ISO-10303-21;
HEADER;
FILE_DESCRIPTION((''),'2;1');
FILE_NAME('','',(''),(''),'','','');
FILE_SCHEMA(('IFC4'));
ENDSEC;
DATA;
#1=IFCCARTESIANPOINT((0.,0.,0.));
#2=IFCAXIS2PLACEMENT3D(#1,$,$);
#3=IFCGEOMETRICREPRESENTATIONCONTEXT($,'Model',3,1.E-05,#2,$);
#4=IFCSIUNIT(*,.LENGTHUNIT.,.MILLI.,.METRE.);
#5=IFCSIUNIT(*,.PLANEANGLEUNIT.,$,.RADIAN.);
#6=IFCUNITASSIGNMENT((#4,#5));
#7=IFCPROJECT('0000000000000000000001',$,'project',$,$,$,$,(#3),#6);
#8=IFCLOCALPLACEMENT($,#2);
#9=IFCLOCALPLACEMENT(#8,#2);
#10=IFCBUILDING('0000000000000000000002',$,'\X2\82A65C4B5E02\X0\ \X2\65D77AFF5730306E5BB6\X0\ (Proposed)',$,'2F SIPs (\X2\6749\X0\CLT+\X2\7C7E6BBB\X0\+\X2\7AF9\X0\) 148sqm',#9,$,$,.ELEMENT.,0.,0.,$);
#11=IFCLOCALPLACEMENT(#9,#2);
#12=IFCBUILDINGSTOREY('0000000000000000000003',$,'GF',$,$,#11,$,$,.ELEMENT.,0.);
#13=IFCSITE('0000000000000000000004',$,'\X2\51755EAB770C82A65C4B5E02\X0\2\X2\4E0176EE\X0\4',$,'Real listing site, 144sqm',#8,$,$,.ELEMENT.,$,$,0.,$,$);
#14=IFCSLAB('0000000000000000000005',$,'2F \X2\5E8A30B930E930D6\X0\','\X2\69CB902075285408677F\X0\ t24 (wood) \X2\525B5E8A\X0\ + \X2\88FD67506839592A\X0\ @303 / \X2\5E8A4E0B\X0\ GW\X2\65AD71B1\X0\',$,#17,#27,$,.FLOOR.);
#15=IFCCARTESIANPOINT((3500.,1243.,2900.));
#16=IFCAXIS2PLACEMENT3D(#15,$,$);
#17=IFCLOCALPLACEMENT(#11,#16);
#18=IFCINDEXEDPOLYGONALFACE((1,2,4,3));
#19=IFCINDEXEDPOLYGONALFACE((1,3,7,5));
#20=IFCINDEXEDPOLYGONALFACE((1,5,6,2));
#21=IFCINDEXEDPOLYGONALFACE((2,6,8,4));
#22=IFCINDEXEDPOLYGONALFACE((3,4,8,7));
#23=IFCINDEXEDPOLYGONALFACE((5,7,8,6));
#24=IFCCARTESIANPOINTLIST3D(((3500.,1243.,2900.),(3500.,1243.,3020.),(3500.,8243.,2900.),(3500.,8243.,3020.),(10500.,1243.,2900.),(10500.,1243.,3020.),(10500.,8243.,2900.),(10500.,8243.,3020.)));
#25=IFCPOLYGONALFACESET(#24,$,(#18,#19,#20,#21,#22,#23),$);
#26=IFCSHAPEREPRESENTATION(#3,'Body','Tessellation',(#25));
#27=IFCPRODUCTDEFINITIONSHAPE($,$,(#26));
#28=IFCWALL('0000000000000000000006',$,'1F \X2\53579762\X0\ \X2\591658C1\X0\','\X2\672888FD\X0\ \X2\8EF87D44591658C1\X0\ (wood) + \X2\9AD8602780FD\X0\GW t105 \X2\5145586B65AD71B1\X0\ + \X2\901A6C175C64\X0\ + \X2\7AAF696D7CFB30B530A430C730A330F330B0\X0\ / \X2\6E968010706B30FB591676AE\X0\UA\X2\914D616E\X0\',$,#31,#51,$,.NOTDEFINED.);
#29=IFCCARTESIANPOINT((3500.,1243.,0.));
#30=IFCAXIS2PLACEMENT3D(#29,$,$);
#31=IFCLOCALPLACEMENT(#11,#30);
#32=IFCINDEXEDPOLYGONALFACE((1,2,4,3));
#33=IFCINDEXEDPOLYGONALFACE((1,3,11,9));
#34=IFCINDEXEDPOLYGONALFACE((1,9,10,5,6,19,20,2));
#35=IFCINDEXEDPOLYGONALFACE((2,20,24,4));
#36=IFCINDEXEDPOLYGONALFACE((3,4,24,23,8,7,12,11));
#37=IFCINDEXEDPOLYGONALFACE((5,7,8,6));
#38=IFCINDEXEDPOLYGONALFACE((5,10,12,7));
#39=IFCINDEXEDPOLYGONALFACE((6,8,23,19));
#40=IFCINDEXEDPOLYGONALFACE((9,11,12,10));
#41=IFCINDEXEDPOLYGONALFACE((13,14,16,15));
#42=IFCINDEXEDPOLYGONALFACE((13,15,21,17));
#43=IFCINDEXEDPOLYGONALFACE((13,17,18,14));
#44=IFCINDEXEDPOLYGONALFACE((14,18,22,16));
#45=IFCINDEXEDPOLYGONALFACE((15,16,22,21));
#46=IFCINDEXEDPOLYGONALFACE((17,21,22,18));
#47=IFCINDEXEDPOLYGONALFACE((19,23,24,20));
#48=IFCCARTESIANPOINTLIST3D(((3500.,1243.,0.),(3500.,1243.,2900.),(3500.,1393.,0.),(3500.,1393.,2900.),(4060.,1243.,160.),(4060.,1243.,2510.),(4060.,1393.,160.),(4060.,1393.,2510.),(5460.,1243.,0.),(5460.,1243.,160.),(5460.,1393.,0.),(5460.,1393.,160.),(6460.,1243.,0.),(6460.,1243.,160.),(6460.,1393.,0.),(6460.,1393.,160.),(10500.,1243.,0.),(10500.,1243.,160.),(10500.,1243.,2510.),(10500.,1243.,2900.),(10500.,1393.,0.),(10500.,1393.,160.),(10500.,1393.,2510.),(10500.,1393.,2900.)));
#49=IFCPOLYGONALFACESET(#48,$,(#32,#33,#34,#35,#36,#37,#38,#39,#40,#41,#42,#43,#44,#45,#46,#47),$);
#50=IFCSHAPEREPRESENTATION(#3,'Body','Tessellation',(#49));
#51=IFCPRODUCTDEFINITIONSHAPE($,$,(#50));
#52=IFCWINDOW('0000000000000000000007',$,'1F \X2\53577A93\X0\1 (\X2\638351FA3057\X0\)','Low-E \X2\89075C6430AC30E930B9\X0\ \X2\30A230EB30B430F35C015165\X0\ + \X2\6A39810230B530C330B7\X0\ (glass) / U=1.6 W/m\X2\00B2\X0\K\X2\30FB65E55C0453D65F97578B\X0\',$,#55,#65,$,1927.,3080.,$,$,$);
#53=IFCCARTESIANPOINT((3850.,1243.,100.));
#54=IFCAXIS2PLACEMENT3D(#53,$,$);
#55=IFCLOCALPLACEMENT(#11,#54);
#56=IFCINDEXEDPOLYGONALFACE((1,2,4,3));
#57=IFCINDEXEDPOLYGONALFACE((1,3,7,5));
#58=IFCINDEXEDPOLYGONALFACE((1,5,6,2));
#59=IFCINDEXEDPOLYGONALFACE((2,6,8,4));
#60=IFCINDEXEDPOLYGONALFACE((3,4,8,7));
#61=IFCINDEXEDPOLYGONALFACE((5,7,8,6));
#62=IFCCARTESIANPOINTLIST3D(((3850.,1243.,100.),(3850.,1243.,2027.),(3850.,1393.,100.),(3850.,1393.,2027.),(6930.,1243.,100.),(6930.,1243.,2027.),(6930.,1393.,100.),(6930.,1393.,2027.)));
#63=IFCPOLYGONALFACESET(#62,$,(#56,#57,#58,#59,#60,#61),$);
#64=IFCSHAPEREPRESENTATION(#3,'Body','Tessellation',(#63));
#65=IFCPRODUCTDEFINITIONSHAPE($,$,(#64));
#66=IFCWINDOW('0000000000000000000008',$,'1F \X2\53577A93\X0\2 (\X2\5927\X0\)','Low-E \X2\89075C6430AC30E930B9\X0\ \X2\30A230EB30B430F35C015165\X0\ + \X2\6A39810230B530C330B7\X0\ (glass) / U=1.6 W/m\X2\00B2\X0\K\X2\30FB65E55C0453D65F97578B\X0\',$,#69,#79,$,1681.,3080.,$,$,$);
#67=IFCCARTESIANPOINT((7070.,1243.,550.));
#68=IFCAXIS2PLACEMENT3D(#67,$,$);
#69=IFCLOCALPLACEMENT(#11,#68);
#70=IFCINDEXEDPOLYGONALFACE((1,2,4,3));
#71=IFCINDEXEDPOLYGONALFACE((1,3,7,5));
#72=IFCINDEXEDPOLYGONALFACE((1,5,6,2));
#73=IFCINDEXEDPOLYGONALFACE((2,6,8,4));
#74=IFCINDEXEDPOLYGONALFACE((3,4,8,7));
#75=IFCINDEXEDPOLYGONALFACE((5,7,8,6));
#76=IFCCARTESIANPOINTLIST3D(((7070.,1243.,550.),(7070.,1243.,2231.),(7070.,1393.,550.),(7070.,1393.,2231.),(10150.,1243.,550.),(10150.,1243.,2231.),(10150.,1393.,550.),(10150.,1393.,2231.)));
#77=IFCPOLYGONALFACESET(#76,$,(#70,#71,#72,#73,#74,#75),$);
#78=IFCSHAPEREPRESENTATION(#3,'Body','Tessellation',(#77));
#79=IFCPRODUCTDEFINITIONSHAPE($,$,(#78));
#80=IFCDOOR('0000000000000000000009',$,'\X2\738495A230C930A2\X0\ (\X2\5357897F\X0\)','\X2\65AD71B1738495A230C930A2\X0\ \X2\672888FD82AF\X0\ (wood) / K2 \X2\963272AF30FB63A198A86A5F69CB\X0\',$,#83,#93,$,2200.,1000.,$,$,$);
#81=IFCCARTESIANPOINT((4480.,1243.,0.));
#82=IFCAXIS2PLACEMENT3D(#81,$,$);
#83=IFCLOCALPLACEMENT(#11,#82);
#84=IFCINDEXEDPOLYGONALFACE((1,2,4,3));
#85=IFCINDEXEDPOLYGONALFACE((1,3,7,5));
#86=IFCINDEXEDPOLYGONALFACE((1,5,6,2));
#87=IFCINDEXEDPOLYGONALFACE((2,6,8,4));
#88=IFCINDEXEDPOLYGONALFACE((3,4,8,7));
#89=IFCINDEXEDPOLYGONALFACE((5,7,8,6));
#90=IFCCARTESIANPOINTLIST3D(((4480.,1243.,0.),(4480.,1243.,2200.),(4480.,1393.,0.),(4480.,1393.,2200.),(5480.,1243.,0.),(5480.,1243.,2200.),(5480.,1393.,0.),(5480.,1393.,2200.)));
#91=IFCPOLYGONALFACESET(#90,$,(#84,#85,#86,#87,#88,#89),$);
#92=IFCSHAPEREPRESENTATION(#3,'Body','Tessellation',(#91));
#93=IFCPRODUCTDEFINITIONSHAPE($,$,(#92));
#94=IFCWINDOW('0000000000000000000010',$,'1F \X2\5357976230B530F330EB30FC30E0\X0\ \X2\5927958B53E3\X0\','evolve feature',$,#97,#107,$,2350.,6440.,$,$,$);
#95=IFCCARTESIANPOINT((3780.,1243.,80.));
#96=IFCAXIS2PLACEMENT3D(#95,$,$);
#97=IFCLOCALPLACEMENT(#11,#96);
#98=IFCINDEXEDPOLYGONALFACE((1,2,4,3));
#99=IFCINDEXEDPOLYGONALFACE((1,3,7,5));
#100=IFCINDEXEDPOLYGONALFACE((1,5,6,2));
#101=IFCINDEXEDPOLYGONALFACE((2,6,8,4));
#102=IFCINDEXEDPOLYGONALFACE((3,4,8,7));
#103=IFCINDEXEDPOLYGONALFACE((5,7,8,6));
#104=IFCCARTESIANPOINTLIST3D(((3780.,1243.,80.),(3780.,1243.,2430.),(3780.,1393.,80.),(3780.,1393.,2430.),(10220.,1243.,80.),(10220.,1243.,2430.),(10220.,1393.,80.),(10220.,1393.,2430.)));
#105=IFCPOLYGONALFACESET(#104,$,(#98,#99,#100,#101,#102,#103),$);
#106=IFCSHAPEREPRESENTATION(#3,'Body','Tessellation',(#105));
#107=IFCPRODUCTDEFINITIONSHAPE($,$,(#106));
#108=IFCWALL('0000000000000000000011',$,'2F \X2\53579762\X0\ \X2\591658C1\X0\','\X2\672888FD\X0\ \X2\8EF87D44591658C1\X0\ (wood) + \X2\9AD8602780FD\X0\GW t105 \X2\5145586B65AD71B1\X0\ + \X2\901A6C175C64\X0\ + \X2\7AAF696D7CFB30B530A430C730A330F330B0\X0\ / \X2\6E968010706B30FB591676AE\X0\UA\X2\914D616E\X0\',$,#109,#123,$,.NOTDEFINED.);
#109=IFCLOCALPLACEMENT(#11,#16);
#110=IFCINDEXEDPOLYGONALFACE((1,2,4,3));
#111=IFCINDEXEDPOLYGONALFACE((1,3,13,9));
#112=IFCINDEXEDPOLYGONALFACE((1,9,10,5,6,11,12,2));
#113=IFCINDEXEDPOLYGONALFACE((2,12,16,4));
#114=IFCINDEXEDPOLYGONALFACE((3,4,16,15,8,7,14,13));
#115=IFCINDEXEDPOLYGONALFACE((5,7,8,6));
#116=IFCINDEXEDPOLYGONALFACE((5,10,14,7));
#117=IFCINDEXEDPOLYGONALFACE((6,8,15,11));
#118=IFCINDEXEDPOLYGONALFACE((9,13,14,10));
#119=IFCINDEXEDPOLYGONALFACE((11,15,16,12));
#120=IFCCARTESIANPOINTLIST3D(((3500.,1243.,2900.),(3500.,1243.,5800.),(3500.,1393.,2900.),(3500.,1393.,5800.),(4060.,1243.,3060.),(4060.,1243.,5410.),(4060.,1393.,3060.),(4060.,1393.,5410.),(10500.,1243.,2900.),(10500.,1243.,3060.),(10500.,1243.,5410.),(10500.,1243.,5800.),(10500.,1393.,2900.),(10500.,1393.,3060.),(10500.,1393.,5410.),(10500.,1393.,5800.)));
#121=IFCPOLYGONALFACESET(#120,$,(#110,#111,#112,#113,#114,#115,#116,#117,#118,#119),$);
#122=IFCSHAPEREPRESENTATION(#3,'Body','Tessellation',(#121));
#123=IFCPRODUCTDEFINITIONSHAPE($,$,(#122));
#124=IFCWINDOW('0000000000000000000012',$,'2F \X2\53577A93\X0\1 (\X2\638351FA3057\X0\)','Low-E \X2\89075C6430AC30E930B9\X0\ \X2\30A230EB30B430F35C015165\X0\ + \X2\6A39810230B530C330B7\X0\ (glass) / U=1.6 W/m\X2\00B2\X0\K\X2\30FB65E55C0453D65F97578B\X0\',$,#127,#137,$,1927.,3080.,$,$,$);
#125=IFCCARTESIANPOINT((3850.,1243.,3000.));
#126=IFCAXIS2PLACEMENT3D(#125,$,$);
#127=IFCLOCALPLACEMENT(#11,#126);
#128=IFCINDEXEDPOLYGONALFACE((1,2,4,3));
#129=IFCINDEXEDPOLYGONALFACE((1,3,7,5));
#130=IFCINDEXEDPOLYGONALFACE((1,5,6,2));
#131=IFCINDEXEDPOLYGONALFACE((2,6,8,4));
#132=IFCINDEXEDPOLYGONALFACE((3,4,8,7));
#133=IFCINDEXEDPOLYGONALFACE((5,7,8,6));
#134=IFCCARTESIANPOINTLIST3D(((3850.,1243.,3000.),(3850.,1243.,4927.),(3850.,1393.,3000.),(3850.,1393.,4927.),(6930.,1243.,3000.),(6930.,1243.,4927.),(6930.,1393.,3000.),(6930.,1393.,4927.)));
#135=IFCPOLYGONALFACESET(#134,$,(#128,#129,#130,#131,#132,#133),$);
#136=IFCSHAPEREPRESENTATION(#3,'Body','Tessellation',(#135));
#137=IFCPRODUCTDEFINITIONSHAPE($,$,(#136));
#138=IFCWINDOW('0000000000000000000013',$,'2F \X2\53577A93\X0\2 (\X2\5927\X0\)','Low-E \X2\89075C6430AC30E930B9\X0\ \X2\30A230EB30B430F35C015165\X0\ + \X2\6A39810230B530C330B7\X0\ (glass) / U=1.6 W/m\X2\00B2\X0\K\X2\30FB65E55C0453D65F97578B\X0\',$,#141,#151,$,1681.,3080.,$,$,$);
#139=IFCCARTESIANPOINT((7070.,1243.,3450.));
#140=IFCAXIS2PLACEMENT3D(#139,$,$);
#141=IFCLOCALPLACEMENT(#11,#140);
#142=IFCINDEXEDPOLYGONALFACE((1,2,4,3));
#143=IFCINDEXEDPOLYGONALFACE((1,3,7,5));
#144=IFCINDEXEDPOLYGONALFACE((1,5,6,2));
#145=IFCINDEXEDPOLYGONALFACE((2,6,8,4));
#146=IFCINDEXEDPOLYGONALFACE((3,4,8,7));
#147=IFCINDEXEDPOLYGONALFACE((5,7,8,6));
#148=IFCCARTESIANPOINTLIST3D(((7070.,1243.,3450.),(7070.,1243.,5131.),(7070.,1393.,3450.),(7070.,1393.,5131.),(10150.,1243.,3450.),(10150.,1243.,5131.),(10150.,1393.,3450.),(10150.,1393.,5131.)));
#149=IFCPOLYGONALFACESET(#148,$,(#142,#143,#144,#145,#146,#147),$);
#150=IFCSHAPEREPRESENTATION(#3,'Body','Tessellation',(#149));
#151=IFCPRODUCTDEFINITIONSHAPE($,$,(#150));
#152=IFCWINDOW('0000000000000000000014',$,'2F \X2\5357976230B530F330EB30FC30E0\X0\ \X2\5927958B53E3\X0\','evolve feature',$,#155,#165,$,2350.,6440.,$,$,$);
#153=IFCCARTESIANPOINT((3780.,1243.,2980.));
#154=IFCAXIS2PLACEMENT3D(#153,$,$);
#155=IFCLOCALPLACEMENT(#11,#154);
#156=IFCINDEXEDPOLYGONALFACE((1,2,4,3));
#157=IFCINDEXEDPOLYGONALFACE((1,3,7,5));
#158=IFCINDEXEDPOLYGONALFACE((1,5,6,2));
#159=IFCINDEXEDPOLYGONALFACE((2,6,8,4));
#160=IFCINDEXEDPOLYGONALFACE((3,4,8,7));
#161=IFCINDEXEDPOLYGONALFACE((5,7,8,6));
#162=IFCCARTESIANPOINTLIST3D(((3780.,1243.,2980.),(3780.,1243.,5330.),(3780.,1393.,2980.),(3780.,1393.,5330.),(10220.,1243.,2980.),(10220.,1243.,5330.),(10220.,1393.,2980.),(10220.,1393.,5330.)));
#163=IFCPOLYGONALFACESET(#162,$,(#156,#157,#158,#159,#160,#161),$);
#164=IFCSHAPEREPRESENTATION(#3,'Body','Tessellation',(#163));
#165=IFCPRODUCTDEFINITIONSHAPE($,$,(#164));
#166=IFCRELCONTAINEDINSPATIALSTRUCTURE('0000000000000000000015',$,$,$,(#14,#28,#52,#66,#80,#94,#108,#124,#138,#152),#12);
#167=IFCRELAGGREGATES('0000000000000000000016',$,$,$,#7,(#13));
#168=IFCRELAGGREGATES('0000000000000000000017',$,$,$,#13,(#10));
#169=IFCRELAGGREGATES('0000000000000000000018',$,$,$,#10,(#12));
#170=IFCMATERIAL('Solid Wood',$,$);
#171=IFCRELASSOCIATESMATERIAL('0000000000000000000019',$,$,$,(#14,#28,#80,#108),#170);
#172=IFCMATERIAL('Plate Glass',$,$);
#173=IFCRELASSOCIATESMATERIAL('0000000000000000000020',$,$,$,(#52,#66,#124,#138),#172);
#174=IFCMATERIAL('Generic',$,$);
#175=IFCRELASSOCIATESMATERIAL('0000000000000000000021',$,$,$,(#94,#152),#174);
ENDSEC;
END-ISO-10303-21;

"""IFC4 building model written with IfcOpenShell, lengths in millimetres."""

from ifc_helpers import new_model, si_unit, frame, frame_2d, origin, place, context, project, spatial, rectangle, extrude, material, element, fill, save


model = new_model("IFC4")

# Units and contexts
model_context = context("Model", 3, precision=1e-05, world=origin())
ifc_project = project(units=[si_unit("LENGTHUNIT", "METRE", prefix="MILLI"), si_unit("PLANEANGLEUNIT", "RADIAN")], contexts=[model_context])

# Site, building, storey
site_placement = place(None, origin())
site = spatial("IfcSite", under=ifc_project, at=site_placement, Name="兵庫県芦屋市2丁目4", ObjectType="Real listing site, 144sqm", CompositionType="ELEMENT", RefElevation=0.0)
building_placement = place(site_placement, origin())
building = spatial("IfcBuilding", under=site, at=building_placement, Name="芦屋市 旗竿地の家 (Proposed)", ObjectType="2F SIPs (杉CLT+籾殻+竹) 148sqm", CompositionType="ELEMENT", ElevationOfRefHeight=0.0, ElevationOfTerrain=0.0)
storey_placement = place(building_placement, origin())
storey = spatial("IfcBuildingStorey", under=building, at=storey_placement, Name="GF", CompositionType="ELEMENT", Elevation=0.0)

# Slab
ifc_material_1 = material(Name="Solid Wood")
slab_1_placement = place(storey_placement, frame((3500.0, 1243.0, 2900.0)))
element("IfcSlab", 1, at=slab_1_placement, inside=storey, material=ifc_material_1, Name="2F 床スラブ", Description="構造用合板 t24 (wood) 剛床 + 製材根太 @303 / 床下 GW断熱", PredefinedType="FLOOR", context=model_context, shape_type="SweptSolid", body=[
    extrude(rectangle(XDim=7000.0, YDim=7000.0, at=frame_2d((3500.0, 3500.0))), frame((3500.0, 1243.0, 2900.0)), (0.0, 0.0, 1.0), 120.0),
])
ifc_material_2 = material(Name="Generic")

# Wall, openings, windows, door
wall_1_placement = place(storey_placement, frame((3500.0, 1243.0, 0.0)))
wall_1 = element("IfcWall", 2, at=wall_1_placement, inside=storey, material=ifc_material_1, Name="1F 南面 外壁", Description="木製 軸組外壁 (wood) + 高性能GW t105 充填断熱 + 通気層 + 窯業系サイディング / 準耐火・外皮UA配慮", PredefinedType="NOTDEFINED", context=model_context, shape_type="SweptSolid", body=[
    extrude(rectangle(XDim=7000.0, YDim=150.0, at=frame_2d((3500.0, 75.0))), frame((3500.0, 1243.0, 0.0)), (0.0, 0.0, 1.0), 2900.0),
])
opening_1_placement = place(storey_placement, frame((3850.0, 1243.0, 100.0)))
opening_1 = element("IfcOpeningElement", 3, at=opening_1_placement, cuts=wall_1, PredefinedType="NOTDEFINED", context=model_context, shape_type="SweptSolid", body=[
    extrude(rectangle(XDim=3080.0, YDim=150.0, at=frame_2d((1540.0, 75.0))), frame((3850.0, 1243.0, 100.0)), (0.0, 0.0, 1.0), 1927.0),
])
opening_2_placement = place(storey_placement, frame((7070.0, 1243.0, 550.0)))
opening_2 = element("IfcOpeningElement", 4, at=opening_2_placement, cuts=wall_1, PredefinedType="NOTDEFINED", context=model_context, shape_type="SweptSolid", body=[
    extrude(rectangle(XDim=3080.0, YDim=150.0, at=frame_2d((1540.0, 75.0))), frame((7070.0, 1243.0, 550.0)), (0.0, 0.0, 1.0), 1681.0),
])
opening_3_placement = place(storey_placement, frame((4480.0, 1243.0, 0.0)))
opening_3 = element("IfcOpeningElement", 5, at=opening_3_placement, cuts=wall_1, PredefinedType="NOTDEFINED", context=model_context, shape_type="SweptSolid", body=[
    extrude(rectangle(XDim=1000.0, YDim=150.0, at=frame_2d((500.0, 75.0))), frame((4480.0, 1243.0, 0.0)), (0.0, 0.0, 1.0), 2200.0),
])
opening_4_placement = place(storey_placement, frame((3780.0, 1243.0, 80.0)))
opening_4 = element("IfcOpeningElement", 6, at=opening_4_placement, cuts=wall_1, PredefinedType="NOTDEFINED", context=model_context, shape_type="SweptSolid", body=[
    extrude(rectangle(XDim=6440.0, YDim=150.0, at=frame_2d((3220.0, 75.0))), frame((3780.0, 1243.0, 80.0)), (0.0, 0.0, 1.0), 2350.0),
])
ifc_material_3 = material(Name="Plate Glass")
window_1_placement = place(storey_placement, frame((3850.0, 1243.0, 100.0)))
window_1 = element("IfcWindow", 7, at=window_1_placement, inside=storey, material=ifc_material_3, Name="1F 南窓1 (掃出し)", Description="Low-E 複層ガラス アルゴン封入 + 樹脂サッシ (glass) / U=1.6 W/m²K・日射取得型", OverallHeight=1927.0, OverallWidth=3080.0, context=model_context, shape_type="SweptSolid", body=[
    extrude(rectangle(XDim=3080.0, YDim=150.0, at=frame_2d((1540.0, 75.0))), frame((3850.0, 1243.0, 100.0)), (0.0, 0.0, 1.0), 1927.0),
])
fill(opening_1, window_1)
window_2_placement = place(storey_placement, frame((7070.0, 1243.0, 550.0)))
window_2 = element("IfcWindow", 8, at=window_2_placement, inside=storey, material=ifc_material_3, Name="1F 南窓2 (大)", Description="Low-E 複層ガラス アルゴン封入 + 樹脂サッシ (glass) / U=1.6 W/m²K・日射取得型", OverallHeight=1681.0, OverallWidth=3080.0, context=model_context, shape_type="SweptSolid", body=[
    extrude(rectangle(XDim=3080.0, YDim=150.0, at=frame_2d((1540.0, 75.0))), frame((7070.0, 1243.0, 550.0)), (0.0, 0.0, 1.0), 1681.0),
])
fill(opening_2, window_2)
door_placement = place(storey_placement, frame((4480.0, 1243.0, 0.0)))
door = element("IfcDoor", 9, at=door_placement, inside=storey, material=ifc_material_1, Name="玄関ドア (南西)", Description="断熱玄関ドア 木製芯 (wood) / K2 防犯・採風機構", OverallHeight=2200.0, OverallWidth=1000.0, context=model_context, shape_type="SweptSolid", body=[
    extrude(rectangle(XDim=1000.0, YDim=150.0, at=frame_2d((500.0, 75.0))), frame((4480.0, 1243.0, 0.0)), (0.0, 0.0, 1.0), 2200.0),
])
fill(opening_3, door)
window_3_placement = place(storey_placement, frame((3780.0, 1243.0, 80.0)))
window_3 = element("IfcWindow", 10, at=window_3_placement, inside=storey, material=ifc_material_2, Name="1F 南面サンルーム 大開口", Description="evolve feature", OverallHeight=2350.0, OverallWidth=6440.0, context=model_context, shape_type="SweptSolid", body=[
    extrude(rectangle(XDim=6440.0, YDim=150.0, at=frame_2d((3220.0, 75.0))), frame((3780.0, 1243.0, 80.0)), (0.0, 0.0, 1.0), 2350.0),
])
fill(opening_4, window_3)

# Wall, openings, windows
wall_2_placement = place(storey_placement, frame((3500.0, 1243.0, 2900.0)))
wall_2 = element("IfcWall", 11, at=wall_2_placement, inside=storey, material=ifc_material_1, Name="2F 南面 外壁", Description="木製 軸組外壁 (wood) + 高性能GW t105 充填断熱 + 通気層 + 窯業系サイディング / 準耐火・外皮UA配慮", PredefinedType="NOTDEFINED", context=model_context, shape_type="SweptSolid", body=[
    extrude(rectangle(XDim=7000.0, YDim=150.0, at=frame_2d((3500.0, 75.0))), frame((3500.0, 1243.0, 2900.0)), (0.0, 0.0, 1.0), 2900.0),
])
opening_5_placement = place(storey_placement, frame((3850.0, 1243.0, 3000.0)))
opening_5 = element("IfcOpeningElement", 12, at=opening_5_placement, cuts=wall_2, PredefinedType="NOTDEFINED", context=model_context, shape_type="SweptSolid", body=[
    extrude(rectangle(XDim=3080.0, YDim=150.0, at=frame_2d((1540.0, 75.0))), frame((3850.0, 1243.0, 3000.0)), (0.0, 0.0, 1.0), 1927.0),
])
opening_6_placement = place(storey_placement, frame((7070.0, 1243.0, 3450.0)))
opening_6 = element("IfcOpeningElement", 13, at=opening_6_placement, cuts=wall_2, PredefinedType="NOTDEFINED", context=model_context, shape_type="SweptSolid", body=[
    extrude(rectangle(XDim=3080.0, YDim=150.0, at=frame_2d((1540.0, 75.0))), frame((7070.0, 1243.0, 3450.0)), (0.0, 0.0, 1.0), 1681.0),
])
opening_7_placement = place(storey_placement, frame((3780.0, 1243.0, 2980.0)))
opening_7 = element("IfcOpeningElement", 14, at=opening_7_placement, cuts=wall_2, PredefinedType="NOTDEFINED", context=model_context, shape_type="SweptSolid", body=[
    extrude(rectangle(XDim=6440.0, YDim=150.0, at=frame_2d((3220.0, 75.0))), frame((3780.0, 1243.0, 2980.0)), (0.0, 0.0, 1.0), 2350.0),
])
window_4_placement = place(storey_placement, frame((3850.0, 1243.0, 3000.0)))
window_4 = element("IfcWindow", 15, at=window_4_placement, inside=storey, material=ifc_material_3, Name="2F 南窓1 (掃出し)", Description="Low-E 複層ガラス アルゴン封入 + 樹脂サッシ (glass) / U=1.6 W/m²K・日射取得型", OverallHeight=1927.0, OverallWidth=3080.0, context=model_context, shape_type="SweptSolid", body=[
    extrude(rectangle(XDim=3080.0, YDim=150.0, at=frame_2d((1540.0, 75.0))), frame((3850.0, 1243.0, 3000.0)), (0.0, 0.0, 1.0), 1927.0),
])
fill(opening_5, window_4)
window_5_placement = place(storey_placement, frame((7070.0, 1243.0, 3450.0)))
window_5 = element("IfcWindow", 16, at=window_5_placement, inside=storey, material=ifc_material_3, Name="2F 南窓2 (大)", Description="Low-E 複層ガラス アルゴン封入 + 樹脂サッシ (glass) / U=1.6 W/m²K・日射取得型", OverallHeight=1681.0, OverallWidth=3080.0, context=model_context, shape_type="SweptSolid", body=[
    extrude(rectangle(XDim=3080.0, YDim=150.0, at=frame_2d((1540.0, 75.0))), frame((7070.0, 1243.0, 3450.0)), (0.0, 0.0, 1.0), 1681.0),
])
fill(opening_6, window_5)
window_6_placement = place(storey_placement, frame((3780.0, 1243.0, 2980.0)))
window_6 = element("IfcWindow", 17, at=window_6_placement, inside=storey, material=ifc_material_2, Name="2F 南面サンルーム 大開口", Description="evolve feature", OverallHeight=2350.0, OverallWidth=6440.0, context=model_context, shape_type="SweptSolid", body=[
    extrude(rectangle(XDim=6440.0, YDim=150.0, at=frame_2d((3220.0, 75.0))), frame((3780.0, 1243.0, 2980.0)), (0.0, 0.0, 1.0), 2350.0),
])
fill(opening_7, window_6)

save(model, "model.ifc")
